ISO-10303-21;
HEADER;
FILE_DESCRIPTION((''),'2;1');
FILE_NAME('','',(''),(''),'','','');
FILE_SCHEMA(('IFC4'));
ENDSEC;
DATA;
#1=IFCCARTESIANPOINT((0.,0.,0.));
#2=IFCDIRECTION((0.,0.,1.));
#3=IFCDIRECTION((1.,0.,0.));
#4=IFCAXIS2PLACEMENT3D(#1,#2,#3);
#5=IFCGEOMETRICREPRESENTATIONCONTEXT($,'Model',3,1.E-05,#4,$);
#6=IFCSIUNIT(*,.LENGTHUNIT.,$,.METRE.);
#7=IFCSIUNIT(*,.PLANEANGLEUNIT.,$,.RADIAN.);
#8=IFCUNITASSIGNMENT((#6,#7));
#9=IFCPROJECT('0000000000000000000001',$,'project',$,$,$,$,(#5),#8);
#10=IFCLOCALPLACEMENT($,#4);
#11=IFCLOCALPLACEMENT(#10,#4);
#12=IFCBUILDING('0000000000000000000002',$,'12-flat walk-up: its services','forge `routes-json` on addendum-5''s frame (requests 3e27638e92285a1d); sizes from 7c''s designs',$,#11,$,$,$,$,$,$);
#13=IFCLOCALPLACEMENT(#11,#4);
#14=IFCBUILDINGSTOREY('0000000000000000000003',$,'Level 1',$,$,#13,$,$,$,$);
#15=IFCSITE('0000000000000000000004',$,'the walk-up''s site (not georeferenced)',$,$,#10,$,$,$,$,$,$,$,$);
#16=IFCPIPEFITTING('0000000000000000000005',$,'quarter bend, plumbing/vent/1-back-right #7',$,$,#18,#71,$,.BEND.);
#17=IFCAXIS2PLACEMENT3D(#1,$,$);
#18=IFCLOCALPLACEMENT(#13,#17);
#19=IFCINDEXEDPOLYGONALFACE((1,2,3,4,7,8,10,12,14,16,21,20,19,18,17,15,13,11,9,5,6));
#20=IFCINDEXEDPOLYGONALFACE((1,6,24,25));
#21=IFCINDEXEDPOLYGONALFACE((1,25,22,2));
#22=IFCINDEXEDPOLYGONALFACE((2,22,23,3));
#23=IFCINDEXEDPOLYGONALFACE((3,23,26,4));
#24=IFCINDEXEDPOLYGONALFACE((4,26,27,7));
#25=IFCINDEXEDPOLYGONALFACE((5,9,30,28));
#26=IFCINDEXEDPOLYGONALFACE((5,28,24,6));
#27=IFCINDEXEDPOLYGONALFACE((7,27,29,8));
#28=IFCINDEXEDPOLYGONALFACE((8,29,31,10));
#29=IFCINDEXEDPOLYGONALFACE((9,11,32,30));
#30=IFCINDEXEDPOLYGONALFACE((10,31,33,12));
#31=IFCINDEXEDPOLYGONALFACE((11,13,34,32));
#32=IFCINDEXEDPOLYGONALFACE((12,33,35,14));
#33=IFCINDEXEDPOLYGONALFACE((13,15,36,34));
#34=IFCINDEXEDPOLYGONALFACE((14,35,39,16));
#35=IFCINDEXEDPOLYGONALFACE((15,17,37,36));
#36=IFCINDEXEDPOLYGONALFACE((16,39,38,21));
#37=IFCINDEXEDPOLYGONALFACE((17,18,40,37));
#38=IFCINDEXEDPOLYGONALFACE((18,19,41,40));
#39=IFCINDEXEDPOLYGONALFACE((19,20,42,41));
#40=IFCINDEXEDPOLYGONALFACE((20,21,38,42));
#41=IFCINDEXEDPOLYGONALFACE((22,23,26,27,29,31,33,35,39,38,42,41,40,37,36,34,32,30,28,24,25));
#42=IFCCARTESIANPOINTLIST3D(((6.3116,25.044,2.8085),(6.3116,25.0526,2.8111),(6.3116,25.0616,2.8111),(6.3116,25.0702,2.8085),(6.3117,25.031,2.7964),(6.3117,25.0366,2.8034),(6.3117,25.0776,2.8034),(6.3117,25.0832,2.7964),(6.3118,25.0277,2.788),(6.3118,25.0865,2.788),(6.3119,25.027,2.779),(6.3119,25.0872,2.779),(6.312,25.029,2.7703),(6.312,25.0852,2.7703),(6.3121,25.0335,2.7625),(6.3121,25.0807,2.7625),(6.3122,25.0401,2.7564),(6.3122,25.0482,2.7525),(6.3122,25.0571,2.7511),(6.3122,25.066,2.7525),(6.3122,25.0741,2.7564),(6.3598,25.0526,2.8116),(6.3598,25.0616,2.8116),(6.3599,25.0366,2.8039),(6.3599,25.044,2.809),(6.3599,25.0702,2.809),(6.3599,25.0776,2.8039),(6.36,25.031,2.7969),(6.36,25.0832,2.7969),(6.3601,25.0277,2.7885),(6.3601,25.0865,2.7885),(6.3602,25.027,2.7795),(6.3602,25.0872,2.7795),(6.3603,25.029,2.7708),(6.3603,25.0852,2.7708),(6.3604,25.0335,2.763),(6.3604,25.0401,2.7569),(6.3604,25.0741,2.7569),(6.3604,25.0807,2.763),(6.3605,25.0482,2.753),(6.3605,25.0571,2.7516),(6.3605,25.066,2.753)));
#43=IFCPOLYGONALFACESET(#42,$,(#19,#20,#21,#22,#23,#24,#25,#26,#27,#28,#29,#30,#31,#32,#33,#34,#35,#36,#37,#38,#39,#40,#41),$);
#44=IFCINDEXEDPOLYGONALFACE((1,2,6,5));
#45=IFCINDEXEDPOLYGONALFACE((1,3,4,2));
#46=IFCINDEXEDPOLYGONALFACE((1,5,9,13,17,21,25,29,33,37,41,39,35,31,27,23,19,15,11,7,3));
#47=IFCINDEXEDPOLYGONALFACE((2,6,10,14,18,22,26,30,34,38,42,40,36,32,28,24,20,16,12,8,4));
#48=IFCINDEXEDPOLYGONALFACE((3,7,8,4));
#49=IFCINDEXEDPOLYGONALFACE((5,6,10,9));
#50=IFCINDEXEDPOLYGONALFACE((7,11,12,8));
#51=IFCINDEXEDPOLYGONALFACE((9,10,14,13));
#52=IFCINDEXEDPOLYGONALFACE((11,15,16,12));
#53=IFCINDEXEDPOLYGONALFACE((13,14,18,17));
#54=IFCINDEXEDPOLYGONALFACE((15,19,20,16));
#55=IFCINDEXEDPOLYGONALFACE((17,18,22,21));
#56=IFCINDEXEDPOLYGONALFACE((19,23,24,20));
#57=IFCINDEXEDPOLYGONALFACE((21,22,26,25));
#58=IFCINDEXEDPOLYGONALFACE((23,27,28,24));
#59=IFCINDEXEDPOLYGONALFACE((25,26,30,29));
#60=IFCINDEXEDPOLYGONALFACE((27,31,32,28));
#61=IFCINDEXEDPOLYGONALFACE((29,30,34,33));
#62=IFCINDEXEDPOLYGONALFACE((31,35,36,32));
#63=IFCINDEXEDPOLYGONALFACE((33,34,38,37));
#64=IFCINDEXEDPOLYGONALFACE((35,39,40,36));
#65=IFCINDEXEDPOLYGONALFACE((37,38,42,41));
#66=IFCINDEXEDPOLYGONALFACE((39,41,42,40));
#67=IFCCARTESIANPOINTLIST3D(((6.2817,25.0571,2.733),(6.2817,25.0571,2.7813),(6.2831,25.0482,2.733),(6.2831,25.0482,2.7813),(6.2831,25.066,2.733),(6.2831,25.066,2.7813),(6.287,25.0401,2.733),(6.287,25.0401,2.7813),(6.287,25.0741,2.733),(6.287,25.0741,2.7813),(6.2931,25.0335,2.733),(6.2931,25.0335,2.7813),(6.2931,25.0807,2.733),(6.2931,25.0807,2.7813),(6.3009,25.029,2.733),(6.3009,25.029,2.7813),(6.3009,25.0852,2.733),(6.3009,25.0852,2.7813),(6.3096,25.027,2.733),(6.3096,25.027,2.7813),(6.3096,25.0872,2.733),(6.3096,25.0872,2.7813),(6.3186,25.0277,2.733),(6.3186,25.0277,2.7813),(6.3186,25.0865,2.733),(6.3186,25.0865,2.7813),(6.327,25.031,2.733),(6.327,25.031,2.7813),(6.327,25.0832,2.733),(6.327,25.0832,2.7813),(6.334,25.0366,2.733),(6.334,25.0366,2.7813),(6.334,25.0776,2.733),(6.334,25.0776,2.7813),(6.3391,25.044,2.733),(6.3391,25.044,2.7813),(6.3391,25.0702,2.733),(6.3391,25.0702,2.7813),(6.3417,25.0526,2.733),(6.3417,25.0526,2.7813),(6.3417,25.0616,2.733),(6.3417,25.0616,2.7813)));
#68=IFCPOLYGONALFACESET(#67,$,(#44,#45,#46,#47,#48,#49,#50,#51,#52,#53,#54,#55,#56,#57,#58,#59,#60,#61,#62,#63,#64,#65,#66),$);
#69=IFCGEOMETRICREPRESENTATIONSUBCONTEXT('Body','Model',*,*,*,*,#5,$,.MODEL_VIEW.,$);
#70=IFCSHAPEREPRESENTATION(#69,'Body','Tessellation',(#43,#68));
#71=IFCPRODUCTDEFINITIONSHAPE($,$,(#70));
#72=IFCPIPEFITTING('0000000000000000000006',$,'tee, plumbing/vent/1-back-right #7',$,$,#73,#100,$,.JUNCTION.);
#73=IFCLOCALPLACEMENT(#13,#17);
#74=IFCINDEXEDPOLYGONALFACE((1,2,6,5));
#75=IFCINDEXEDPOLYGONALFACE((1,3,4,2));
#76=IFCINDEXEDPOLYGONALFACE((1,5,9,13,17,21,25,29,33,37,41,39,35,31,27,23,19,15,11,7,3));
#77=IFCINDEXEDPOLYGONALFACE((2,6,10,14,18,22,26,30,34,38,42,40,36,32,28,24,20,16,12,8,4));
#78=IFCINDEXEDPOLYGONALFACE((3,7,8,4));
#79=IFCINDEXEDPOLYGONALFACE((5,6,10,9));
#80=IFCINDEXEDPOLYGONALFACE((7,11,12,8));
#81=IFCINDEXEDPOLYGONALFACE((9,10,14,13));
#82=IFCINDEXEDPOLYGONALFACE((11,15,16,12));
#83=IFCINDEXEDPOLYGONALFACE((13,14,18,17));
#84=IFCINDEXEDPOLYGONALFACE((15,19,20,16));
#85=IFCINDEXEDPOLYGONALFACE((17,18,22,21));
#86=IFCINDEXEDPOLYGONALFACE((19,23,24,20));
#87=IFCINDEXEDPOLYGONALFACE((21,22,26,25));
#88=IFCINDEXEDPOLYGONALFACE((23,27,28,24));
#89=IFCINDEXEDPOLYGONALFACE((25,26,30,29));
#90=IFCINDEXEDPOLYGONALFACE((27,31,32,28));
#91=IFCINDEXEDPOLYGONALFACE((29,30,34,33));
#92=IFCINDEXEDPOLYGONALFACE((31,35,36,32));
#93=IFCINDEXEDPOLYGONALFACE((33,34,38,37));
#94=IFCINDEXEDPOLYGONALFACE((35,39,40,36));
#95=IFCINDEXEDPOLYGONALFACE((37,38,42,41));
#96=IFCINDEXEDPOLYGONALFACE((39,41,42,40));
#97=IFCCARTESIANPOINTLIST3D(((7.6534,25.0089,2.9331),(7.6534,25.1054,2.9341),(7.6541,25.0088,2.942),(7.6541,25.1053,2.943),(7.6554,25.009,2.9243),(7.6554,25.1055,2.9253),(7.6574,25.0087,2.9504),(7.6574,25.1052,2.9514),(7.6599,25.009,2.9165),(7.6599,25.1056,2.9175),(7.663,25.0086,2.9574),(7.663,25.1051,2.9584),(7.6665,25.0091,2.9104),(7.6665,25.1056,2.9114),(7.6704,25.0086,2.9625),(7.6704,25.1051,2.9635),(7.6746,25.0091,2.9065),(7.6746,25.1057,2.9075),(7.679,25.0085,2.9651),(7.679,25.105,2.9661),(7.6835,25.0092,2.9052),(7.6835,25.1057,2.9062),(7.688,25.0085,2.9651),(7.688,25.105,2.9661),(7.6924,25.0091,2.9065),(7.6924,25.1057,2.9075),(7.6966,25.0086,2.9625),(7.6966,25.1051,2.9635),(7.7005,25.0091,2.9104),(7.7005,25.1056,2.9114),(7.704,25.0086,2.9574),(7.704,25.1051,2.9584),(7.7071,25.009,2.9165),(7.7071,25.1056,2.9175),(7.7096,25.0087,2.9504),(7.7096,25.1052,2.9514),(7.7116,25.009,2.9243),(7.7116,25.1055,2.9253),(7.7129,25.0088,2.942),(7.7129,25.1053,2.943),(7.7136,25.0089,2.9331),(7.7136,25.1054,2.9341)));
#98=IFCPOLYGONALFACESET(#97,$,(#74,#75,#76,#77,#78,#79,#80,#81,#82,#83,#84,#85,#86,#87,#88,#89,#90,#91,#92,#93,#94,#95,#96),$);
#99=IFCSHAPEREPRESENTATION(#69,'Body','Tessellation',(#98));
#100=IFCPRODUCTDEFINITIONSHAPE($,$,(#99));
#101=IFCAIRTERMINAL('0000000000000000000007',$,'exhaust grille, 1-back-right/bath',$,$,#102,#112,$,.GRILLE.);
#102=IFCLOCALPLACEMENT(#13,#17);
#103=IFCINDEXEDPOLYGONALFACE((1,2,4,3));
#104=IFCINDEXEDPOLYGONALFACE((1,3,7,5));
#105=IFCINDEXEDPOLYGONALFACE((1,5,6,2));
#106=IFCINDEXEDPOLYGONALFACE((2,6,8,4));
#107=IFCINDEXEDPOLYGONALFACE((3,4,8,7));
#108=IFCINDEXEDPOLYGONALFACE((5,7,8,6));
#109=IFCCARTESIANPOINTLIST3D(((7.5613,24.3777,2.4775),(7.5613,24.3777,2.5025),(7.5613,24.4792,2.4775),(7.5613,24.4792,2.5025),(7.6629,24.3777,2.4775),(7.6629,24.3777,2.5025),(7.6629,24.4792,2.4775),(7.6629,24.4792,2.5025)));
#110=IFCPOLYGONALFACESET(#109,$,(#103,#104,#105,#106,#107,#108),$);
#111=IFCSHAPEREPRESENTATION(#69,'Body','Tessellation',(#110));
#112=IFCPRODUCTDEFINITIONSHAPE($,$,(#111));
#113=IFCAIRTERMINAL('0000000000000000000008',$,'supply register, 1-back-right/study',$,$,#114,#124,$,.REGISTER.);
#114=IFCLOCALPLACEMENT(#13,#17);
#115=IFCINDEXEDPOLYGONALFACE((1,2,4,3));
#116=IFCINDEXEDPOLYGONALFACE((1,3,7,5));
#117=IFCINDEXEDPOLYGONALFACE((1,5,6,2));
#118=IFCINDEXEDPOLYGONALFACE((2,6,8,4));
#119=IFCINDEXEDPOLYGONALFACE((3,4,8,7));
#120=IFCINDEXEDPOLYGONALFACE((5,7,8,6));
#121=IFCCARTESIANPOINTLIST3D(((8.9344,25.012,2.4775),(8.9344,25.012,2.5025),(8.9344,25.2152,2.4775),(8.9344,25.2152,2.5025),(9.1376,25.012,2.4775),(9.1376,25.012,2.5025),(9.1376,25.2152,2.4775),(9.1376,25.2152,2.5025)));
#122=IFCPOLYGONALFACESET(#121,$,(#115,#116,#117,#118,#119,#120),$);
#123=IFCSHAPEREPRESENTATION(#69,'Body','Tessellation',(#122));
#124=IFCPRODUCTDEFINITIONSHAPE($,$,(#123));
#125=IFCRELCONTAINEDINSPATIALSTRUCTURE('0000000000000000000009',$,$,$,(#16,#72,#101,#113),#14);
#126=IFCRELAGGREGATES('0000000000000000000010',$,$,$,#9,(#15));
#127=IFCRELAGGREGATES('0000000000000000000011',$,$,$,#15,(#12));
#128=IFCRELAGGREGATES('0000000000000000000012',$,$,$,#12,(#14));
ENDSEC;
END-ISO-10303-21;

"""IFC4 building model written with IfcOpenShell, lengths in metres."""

from ifc_helpers import new_model, entity, si_unit, frame, frame_2d, origin, origin_with_axes, place, context, subcontext, project, spatial, rectangle, extrude, element, save


model = new_model("IFC4")

# Units and contexts
model_context = context("Model", 3, precision=1e-05, world=origin_with_axes())
body_context = subcontext(model_context, "Body", "Model", "MODEL_VIEW")
ifc_project = project(units=[si_unit("LENGTHUNIT", "METRE"), si_unit("PLANEANGLEUNIT", "RADIAN")], contexts=[model_context])

# Site, building, storey
site_placement = place(None, origin_with_axes())
site = spatial("IfcSite", under=ifc_project, at=site_placement, Name="the walk-up's site (not georeferenced)")
building_placement = place(site_placement, origin_with_axes())
building = spatial("IfcBuilding", under=site, at=building_placement, Name="12-flat walk-up: its services", Description="forge `routes-json` on addendum-5's frame (requests 3e27638e92285a1d); sizes from 7c's designs")
storey_placement = place(building_placement, origin_with_axes())
storey = spatial("IfcBuildingStorey", under=building, at=storey_placement, Name="Level 1")

# Pipe fittings
pipe_fitting_1_placement = place(storey_placement, frame((6.3602, 25.0571, 2.7818), z_axis=(0.0, 0.0, 1.0), x_axis=(1.0, 0.0, 0.0)))
element("IfcPipeFitting", 1, at=pipe_fitting_1_placement, inside=storey, Name="quarter bend, plumbing/vent/1-back-right #7", PredefinedType="BEND", context=body_context, shape_type="AdvancedSweptSolid", body=[
    entity("IfcSweptDiskSolid", entity("IfcPolyline", [entity("IfcCartesianPoint", [0.0, 0.0, 0.0]), entity("IfcCartesianPoint", [-0.0483, 0.0, -0.0005])]), 0.0302),
    entity("IfcSweptDiskSolid", entity("IfcPolyline", [entity("IfcCartesianPoint", [-0.0483, 0.0, -0.0005]), entity("IfcCartesianPoint", [-0.0483, 0.0, -0.0488])]), 0.0302),
])
pipe_fitting_2_placement = place(storey_placement, frame((7.6835, 25.1054, 2.9363), z_axis=(0.0, 0.0, 1.0), x_axis=(1.0, 0.0, 0.0)))
element("IfcPipeFitting", 2, at=pipe_fitting_2_placement, inside=storey, Name="tee, plumbing/vent/1-back-right #7", PredefinedType="JUNCTION", context=body_context, shape_type="AdvancedSweptSolid", body=[
    entity("IfcSweptDiskSolid", entity("IfcPolyline", [entity("IfcCartesianPoint", [0.0, 0.0, 0.0]), entity("IfcCartesianPoint", [0.0, -0.0965, -0.001])]), 0.0302),
])

# Air terminals
air_terminal_1_placement = place(storey_placement, frame((7.5613, 24.3777, 2.4775), z_axis=(0.0, 0.0, 1.0), x_axis=(1.0, 0.0, 0.0)))
element("IfcAirTerminal", 3, at=air_terminal_1_placement, inside=storey, Name="exhaust grille, 1-back-right/bath", PredefinedType="GRILLE", context=body_context, shape_type="SweptSolid", body=[
    extrude(rectangle(XDim=0.1016, YDim=0.1016, at=frame_2d((0.0508, 0.0508))), origin(), (0.0, 0.0, 1.0), 0.025),
])
air_terminal_2_placement = place(storey_placement, frame((8.9345, 25.012, 2.4775), z_axis=(0.0, 0.0, 1.0), x_axis=(1.0, 0.0, 0.0)))
element("IfcAirTerminal", 4, at=air_terminal_2_placement, inside=storey, Name="supply register, 1-back-right/study", PredefinedType="REGISTER", context=body_context, shape_type="SweptSolid", body=[
    extrude(rectangle(XDim=0.2032, YDim=0.2032, at=frame_2d((0.1016, 0.1016))), origin(), (0.0, 0.0, 1.0), 0.025),
])

save(model, "model.ifc")
